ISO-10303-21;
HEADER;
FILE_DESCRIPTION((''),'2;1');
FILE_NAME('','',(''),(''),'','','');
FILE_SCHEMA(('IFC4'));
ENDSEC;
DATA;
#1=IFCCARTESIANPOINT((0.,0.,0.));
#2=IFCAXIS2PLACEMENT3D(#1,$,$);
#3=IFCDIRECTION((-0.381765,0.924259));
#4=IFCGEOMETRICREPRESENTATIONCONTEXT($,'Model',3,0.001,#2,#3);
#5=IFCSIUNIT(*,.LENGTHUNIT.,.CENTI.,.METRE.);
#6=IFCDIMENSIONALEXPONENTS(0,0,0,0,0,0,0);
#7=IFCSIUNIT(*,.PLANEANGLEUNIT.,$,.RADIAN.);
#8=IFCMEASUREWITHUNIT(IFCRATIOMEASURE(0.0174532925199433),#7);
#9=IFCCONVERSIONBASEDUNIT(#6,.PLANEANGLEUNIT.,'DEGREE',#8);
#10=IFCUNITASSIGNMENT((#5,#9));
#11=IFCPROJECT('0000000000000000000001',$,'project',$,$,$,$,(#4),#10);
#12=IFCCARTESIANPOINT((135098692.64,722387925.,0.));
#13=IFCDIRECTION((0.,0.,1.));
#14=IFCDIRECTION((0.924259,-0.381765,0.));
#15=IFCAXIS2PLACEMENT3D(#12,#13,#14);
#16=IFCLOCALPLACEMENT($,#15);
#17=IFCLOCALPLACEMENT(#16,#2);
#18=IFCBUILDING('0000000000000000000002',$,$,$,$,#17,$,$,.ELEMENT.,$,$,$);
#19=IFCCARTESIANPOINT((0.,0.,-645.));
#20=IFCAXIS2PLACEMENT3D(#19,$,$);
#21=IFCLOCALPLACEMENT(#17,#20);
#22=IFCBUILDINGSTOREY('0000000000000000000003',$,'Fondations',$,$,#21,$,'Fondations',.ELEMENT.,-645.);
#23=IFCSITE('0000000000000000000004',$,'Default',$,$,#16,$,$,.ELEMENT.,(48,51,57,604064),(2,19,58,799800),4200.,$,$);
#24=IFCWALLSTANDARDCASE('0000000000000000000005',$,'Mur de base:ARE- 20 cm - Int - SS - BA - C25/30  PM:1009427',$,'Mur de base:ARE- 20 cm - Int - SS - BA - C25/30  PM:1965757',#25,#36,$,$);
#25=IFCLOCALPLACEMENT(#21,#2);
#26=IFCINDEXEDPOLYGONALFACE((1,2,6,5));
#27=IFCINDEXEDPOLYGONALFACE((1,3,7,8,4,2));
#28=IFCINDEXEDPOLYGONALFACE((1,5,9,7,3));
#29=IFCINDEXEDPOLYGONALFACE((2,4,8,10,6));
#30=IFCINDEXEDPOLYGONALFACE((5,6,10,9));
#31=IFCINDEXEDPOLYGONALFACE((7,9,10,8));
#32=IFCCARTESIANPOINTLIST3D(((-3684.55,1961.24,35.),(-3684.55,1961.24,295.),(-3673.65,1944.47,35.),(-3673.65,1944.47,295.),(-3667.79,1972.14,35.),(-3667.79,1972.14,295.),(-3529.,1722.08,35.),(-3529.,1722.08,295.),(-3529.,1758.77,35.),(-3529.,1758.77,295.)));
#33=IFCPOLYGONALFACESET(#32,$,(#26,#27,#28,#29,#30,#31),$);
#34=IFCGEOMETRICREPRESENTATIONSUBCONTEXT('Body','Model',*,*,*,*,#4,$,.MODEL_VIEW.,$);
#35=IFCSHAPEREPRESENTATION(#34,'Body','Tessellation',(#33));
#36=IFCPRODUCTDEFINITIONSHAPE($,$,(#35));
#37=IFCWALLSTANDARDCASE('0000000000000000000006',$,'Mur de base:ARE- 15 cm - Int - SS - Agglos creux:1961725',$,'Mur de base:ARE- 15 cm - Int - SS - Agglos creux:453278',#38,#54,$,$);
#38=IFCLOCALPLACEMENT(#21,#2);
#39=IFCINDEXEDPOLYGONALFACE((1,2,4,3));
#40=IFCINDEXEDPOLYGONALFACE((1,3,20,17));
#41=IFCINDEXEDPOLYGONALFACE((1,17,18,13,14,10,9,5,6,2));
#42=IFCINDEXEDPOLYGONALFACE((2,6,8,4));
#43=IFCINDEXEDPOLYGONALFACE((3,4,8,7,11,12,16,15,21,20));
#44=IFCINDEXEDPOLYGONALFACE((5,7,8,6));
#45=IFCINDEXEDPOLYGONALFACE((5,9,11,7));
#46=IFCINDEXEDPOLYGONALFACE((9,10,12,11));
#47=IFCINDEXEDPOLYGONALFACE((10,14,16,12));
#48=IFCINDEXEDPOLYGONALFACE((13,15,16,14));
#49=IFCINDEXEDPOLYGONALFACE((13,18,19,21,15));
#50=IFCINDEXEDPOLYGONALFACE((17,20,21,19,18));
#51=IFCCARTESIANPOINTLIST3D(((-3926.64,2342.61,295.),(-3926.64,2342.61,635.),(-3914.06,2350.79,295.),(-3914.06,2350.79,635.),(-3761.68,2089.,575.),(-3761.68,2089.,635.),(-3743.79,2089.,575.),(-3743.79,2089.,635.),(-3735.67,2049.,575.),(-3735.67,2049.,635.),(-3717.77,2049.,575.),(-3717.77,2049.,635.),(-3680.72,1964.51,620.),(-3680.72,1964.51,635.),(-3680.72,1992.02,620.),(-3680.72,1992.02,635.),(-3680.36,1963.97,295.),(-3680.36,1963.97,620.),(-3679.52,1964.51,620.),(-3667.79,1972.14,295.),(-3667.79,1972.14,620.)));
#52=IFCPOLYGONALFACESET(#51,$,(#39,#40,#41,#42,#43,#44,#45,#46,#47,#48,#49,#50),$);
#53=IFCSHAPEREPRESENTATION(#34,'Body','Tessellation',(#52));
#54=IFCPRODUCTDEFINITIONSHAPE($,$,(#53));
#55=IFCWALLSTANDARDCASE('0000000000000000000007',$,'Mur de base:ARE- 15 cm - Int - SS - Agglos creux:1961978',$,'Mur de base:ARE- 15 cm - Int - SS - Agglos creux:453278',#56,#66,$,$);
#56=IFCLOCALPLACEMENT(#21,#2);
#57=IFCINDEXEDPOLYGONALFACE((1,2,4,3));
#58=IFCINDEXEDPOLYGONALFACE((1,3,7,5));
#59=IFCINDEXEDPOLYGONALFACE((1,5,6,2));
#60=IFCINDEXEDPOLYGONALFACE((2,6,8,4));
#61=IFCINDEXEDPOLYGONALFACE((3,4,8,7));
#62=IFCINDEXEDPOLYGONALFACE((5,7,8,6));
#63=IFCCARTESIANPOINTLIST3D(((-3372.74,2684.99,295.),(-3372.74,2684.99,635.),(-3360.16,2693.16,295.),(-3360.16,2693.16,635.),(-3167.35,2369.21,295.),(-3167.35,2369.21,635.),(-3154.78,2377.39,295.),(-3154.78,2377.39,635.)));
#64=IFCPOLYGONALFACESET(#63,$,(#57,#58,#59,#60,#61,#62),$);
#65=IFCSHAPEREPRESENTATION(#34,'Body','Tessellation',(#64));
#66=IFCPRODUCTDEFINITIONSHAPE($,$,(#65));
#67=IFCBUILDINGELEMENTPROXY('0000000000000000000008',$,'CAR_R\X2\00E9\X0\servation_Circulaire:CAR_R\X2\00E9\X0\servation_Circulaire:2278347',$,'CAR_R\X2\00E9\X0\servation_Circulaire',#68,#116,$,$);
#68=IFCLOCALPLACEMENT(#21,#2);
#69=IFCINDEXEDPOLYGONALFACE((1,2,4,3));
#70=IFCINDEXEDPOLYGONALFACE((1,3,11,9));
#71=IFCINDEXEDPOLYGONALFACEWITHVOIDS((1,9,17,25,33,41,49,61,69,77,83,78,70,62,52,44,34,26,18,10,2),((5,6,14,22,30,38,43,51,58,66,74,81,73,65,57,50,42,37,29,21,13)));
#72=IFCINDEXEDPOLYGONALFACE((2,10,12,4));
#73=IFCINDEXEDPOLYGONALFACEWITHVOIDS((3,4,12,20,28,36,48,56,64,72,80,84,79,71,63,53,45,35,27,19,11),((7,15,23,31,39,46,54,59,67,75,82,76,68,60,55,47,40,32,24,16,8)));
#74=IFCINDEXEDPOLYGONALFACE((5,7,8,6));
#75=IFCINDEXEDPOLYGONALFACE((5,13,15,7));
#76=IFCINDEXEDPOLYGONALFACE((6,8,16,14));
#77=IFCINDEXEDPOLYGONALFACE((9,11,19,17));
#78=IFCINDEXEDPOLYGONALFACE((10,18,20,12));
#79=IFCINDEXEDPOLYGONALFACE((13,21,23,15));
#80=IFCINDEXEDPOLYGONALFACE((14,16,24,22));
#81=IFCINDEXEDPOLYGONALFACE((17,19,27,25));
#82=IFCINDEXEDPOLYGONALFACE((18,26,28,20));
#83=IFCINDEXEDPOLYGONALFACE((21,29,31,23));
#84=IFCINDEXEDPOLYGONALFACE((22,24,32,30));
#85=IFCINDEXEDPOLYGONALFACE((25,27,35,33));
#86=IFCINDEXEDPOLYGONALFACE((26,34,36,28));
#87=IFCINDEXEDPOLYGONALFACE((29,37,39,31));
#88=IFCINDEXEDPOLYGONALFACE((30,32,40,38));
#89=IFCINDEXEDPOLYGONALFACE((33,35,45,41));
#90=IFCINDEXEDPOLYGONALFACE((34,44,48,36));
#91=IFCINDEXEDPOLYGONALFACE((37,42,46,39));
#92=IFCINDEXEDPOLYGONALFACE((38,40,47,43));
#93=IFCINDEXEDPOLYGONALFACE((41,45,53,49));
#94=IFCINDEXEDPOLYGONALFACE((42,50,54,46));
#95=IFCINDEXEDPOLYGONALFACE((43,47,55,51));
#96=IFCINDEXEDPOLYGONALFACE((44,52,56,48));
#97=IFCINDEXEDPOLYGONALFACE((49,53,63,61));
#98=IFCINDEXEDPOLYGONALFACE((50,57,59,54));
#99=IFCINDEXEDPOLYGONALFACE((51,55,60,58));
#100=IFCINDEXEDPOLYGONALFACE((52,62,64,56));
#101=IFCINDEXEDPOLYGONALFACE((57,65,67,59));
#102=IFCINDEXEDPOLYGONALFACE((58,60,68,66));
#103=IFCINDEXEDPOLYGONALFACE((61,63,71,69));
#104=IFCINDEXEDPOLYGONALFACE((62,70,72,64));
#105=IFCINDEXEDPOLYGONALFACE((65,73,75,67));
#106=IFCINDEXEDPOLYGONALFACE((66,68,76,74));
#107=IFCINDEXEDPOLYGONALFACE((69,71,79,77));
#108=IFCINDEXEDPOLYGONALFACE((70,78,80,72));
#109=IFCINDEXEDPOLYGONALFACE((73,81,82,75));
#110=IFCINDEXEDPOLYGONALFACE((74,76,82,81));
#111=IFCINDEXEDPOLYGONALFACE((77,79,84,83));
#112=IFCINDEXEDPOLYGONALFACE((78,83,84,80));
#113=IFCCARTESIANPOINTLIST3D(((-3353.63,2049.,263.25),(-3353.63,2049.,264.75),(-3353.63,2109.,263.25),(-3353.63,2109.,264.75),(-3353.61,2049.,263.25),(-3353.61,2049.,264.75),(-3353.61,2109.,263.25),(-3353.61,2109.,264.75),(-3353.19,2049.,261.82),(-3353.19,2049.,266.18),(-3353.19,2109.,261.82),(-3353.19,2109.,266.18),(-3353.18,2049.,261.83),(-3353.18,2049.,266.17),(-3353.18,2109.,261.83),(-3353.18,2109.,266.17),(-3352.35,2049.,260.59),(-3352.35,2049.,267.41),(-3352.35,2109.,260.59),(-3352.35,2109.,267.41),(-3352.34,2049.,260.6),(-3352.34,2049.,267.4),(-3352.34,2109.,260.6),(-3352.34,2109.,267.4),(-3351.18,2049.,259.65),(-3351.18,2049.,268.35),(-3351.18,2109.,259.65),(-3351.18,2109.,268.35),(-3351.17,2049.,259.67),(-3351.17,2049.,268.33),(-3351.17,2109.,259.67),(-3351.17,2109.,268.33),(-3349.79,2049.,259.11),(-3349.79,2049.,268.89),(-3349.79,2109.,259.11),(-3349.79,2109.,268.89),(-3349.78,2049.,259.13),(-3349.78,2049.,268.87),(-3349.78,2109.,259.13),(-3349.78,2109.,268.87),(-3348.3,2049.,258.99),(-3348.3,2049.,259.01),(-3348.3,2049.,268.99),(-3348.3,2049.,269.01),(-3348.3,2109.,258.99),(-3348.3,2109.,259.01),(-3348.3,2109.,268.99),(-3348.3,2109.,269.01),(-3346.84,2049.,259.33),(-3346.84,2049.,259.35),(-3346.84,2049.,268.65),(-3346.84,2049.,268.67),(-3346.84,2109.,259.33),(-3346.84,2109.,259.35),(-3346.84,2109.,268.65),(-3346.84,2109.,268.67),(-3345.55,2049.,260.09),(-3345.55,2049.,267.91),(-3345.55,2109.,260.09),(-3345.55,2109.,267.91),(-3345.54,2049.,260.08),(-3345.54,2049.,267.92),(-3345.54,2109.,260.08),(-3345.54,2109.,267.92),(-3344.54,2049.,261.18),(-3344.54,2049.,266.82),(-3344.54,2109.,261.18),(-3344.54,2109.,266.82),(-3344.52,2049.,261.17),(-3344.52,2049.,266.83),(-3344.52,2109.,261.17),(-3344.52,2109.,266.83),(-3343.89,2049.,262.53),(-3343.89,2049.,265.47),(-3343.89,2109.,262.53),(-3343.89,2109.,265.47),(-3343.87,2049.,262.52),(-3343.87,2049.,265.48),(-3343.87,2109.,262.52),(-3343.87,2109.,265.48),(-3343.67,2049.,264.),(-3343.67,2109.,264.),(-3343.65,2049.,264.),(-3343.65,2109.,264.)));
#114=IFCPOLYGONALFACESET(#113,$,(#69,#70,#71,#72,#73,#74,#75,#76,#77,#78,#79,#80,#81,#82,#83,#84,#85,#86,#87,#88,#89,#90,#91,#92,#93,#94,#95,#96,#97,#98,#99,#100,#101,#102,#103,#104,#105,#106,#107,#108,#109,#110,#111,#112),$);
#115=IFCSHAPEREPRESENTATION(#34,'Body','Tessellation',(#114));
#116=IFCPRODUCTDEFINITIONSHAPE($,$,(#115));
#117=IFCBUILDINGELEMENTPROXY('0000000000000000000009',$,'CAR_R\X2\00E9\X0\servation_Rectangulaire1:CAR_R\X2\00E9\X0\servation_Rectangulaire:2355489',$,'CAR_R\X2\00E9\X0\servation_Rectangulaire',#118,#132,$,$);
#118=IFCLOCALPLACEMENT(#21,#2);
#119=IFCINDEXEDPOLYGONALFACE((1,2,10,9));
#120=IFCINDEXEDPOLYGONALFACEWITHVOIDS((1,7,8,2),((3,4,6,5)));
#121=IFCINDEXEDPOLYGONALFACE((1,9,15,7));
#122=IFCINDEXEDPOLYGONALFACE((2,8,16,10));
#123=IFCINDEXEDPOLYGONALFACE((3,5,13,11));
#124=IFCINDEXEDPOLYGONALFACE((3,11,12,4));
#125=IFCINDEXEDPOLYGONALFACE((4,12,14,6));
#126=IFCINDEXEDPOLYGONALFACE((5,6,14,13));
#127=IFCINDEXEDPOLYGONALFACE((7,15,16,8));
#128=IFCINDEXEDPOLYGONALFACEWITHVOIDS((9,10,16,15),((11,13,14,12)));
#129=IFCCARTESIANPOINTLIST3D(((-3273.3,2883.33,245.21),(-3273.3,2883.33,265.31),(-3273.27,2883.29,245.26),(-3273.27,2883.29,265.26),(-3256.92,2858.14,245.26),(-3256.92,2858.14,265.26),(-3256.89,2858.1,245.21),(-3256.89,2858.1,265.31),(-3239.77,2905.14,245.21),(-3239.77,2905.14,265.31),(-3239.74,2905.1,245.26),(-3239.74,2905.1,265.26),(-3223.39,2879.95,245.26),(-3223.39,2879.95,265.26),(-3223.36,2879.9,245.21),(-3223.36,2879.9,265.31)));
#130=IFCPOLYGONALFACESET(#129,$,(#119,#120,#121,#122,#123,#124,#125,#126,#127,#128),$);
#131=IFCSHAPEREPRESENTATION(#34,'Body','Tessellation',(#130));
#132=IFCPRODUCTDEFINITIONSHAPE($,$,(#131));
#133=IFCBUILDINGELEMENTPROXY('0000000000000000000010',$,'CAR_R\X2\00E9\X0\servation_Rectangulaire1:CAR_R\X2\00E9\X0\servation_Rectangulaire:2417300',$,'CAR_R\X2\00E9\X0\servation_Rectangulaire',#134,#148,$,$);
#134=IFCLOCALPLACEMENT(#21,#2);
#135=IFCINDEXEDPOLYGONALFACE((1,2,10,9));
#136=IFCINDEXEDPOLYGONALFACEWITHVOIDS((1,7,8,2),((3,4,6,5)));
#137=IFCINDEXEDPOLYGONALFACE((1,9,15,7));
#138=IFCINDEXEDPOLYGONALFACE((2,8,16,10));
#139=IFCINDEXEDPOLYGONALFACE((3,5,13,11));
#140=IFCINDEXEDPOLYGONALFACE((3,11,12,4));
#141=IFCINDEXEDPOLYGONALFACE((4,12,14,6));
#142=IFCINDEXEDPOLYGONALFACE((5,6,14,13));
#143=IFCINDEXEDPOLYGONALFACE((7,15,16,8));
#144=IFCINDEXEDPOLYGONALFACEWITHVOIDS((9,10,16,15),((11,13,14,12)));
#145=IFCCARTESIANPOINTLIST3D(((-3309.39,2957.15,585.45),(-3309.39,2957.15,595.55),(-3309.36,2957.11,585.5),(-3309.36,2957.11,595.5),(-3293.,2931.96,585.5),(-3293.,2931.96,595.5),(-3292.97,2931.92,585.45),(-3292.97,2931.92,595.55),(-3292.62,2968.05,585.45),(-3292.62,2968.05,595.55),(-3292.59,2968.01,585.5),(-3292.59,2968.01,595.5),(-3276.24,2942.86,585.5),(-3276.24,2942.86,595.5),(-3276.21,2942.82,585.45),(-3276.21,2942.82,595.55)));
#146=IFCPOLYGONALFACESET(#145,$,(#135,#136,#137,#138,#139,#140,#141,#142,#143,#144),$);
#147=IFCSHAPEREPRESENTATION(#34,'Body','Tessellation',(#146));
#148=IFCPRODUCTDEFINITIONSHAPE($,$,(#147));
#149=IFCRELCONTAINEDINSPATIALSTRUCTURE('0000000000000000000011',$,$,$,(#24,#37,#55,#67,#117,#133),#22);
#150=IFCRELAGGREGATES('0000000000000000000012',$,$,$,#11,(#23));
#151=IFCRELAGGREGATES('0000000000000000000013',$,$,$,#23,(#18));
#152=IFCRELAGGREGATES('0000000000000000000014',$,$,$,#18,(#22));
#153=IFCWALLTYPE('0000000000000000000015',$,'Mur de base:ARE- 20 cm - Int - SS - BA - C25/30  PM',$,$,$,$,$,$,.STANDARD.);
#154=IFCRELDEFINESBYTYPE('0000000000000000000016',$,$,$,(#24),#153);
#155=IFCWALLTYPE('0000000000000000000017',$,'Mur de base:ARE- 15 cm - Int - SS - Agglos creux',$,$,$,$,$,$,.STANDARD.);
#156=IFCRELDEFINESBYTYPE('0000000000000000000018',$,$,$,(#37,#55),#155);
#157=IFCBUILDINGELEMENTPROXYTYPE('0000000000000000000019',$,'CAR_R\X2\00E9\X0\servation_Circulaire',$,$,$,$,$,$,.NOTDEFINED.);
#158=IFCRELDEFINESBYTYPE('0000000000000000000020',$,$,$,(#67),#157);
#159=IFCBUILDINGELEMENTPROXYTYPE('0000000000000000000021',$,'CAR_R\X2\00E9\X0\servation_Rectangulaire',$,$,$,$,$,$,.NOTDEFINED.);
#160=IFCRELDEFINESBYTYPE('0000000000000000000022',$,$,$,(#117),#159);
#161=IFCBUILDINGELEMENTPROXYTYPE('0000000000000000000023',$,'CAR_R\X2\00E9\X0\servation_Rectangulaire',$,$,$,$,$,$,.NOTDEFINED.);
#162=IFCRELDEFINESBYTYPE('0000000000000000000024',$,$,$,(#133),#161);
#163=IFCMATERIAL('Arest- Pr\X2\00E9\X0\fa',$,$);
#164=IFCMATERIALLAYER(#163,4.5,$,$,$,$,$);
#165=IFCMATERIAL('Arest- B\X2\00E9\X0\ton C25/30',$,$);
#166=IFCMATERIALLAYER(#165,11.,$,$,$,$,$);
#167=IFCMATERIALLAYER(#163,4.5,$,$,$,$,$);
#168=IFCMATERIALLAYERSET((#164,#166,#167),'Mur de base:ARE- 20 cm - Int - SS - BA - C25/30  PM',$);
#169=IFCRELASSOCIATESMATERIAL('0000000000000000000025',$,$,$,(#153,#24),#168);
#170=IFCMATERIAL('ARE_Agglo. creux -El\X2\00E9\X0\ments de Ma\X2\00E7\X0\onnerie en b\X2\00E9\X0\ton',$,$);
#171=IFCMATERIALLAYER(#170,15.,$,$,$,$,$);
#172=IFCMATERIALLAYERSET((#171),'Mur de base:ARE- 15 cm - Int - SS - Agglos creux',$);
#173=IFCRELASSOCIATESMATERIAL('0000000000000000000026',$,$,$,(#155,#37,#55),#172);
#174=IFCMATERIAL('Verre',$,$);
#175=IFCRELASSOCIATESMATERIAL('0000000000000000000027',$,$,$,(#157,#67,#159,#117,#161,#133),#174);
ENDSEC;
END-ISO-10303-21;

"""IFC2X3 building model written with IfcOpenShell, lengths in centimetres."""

from ifc_helpers import new_model, entity, si_unit, converted_unit, direction, frame, frame_2d, origin, place, context, subcontext, project, spatial, polyline, rectangle, hollow_circle, outline, extrude, clip, bounded_halfspace, source, transform, mapped, material, layer, layer_set, layer_usage, type_object, type_shapes, element, save


model = new_model("IFC2X3")

# Units and contexts
model_context = context("Model", 3, precision=0.001, world=origin(), true_north=direction((-0.381765, 0.924259)))
body_context = subcontext(model_context, "Body", "Model", "MODEL_VIEW")
ifc_project = project(units=[si_unit("LENGTHUNIT", "METRE", prefix="CENTI"), converted_unit("PLANEANGLEUNIT", "DEGREE", entity("IfcRatioMeasure", 0.0174532925199433), si_unit("PLANEANGLEUNIT", "RADIAN"), dimensions=[0, 0, 0, 0, 0, 0, 0])], contexts=[model_context])

# Site, building, storey
site_placement = place(None, frame((135098692.64, 722387925.0, 0.0), z_axis=(0.0, 0.0, 1.0), x_axis=(0.924259, -0.381765, 0.0)))
site = spatial("IfcSite", under=ifc_project, at=site_placement, Name="Default", CompositionType="ELEMENT", RefLatitude=(48, 51, 57, 604064), RefLongitude=(2, 19, 58, 799800), RefElevation=4200.0)
building_placement = place(site_placement, origin())
building = spatial("IfcBuilding", under=site, at=building_placement, CompositionType="ELEMENT")
storey_placement = place(building_placement, frame((0.0, 0.0, -645.0)))
storey = spatial("IfcBuildingStorey", under=building, at=storey_placement, Name="Fondations", LongName="Fondations", CompositionType="ELEMENT", Elevation=-645.0)

# Walls
ifc_material_1 = material(Name="Arest- Préfa")
ifc_layer_1 = layer(ifc_material_1, 4.5)
ifc_material_2 = material(Name="Arest- Béton C25/30")
ifc_layer_2 = layer(ifc_material_2, 11.0)
ifc_layer_3 = layer(ifc_material_1, 4.5)
ifc_layer_set_1 = layer_set([ifc_layer_1, ifc_layer_2, ifc_layer_3], Name="Mur de base:ARE- 20 cm - Int - SS - BA - C25/30  PM")
ifc_layer_usage_1 = layer_usage(ifc_layer_set_1, "AXIS2", "NEGATIVE", 10.0)
wall_type_1 = type_object("IfcWallType", Name="Mur de base:ARE- 20 cm - Int - SS - BA - C25/30  PM", PredefinedType="STANDARD", material=ifc_layer_set_1)
wall_1_placement = place(storey_placement, frame((-3676.17, 1966.69, 35.0), z_axis=(0.0, 0.0, 1.0), x_axis=(0.545236, -0.838282, 0.0)))
element("IfcWallStandardCase", 1, at=wall_1_placement, inside=storey, type_object=wall_type_1, material=ifc_layer_usage_1, Name="Mur de base:ARE- 20 cm - Int - SS - BA - C25/30  PM:1009427", ObjectType="Mur de base:ARE- 20 cm - Int - SS - BA - C25/30  PM:1965757", context=body_context, shape_type="SweptSolid", body=[
    extrude(outline(polyline([(285.29, -10.0), (254.54, 10.0), (0.0, 10.0), (0.0, -10.0), (20.0, -10.0), (285.29, -10.0)])), origin(), (0.0, 0.0, 1.0), 260.0),
])
ifc_material_3 = material(Name="ARE_Agglo. creux -Eléments de Maçonnerie en béton")
ifc_layer_4 = layer(ifc_material_3, 15.0)
ifc_layer_set_2 = layer_set([ifc_layer_4], Name="Mur de base:ARE- 15 cm - Int - SS - Agglos creux")
ifc_layer_usage_2 = layer_usage(ifc_layer_set_2, "AXIS2", "NEGATIVE", 7.5)
wall_type_2 = type_object("IfcWallType", Name="Mur de base:ARE- 15 cm - Int - SS - Agglos creux", PredefinedType="STANDARD", material=ifc_layer_set_2)
wall_2_placement = place(storey_placement, frame((-3674.07, 1968.06, 295.0), z_axis=(0.0, 0.0, 1.0), x_axis=(-0.545236, 0.838282, 0.0)))
element("IfcWallStandardCase", 2, at=wall_2_placement, inside=storey, type_object=wall_type_2, material=ifc_layer_usage_2, Name="Mur de base:ARE- 15 cm - Int - SS - Agglos creux:1961725", ObjectType="Mur de base:ARE- 15 cm - Int - SS - Agglos creux:453278", context=body_context, shape_type="Clipping", body=[
    clip(clip(clip(extrude(rectangle(XDim=451.69, YDim=15.0, at=frame_2d((225.85, 0.0), x_axis=(-1.0, 0.0))), origin(), (0.0, 0.0, 1.0), 340.0), bounded_halfspace(frame((101.44, 7.5, 280.0), z_axis=(0.0, 0.0, -1.0), x_axis=(0.545236, 0.838282, 0.0)), True, frame((101.44, 7.5, 280.0), z_axis=(0.0, 0.0, -1.0), x_axis=(0.545236, 0.838282, 0.0)), polyline([(0.0, 0.0), (26.02, 40.0), (8.12, 40.0), (-17.89, 0.0), (0.0, 0.0)]))), bounded_halfspace(frame((23.72, -7.5, 325.0), z_axis=(0.0, 0.0, -1.0), x_axis=(-0.838282, 0.545236, 0.0)), True, frame((23.72, -7.5, 325.0), z_axis=(0.0, 0.0, -1.0), x_axis=(-0.838282, 0.545236, 0.0)), polyline([(0.0, 0.0), (19.88, -12.93), (28.06, -0.36), (27.51, 0.0), (0.0, 0.0)]))), bounded_halfspace(frame((0.65, 7.5, 325.0), z_axis=(0.545236, 0.838282, 0.0), x_axis=(-0.838282, 0.545236, 0.0)), True, frame((0.65, 7.5, 325.0), z_axis=(0.545236, 0.838282, 0.0), x_axis=(-0.838282, 0.545236, 0.0)), polyline([(0.0, 0.0), (0.0, 15.0), (-27.51, 15.0), (-27.51, 0.0), (0.0, 0.0)]))),
])
ifc_layer_usage_3 = layer_usage(ifc_layer_set_2, "AXIS2", "NEGATIVE", 7.5)
wall_3_placement = place(storey_placement, frame((-3366.45, 2689.08, 295.0), z_axis=(0.0, 0.0, 1.0), x_axis=(0.545236, -0.838282, 0.0)))
element("IfcWallStandardCase", 3, at=wall_3_placement, inside=storey, type_object=wall_type_2, material=ifc_layer_usage_3, Name="Mur de base:ARE- 15 cm - Int - SS - Agglos creux:1961978", ObjectType="Mur de base:ARE- 15 cm - Int - SS - Agglos creux:453278", context=body_context, shape_type="SweptSolid", body=[
    extrude(rectangle(XDim=376.69, YDim=15.0, at=frame_2d((188.35, 0.0), x_axis=(-1.0, 0.0))), origin(), (0.0, 0.0, 1.0), 340.0),
])

# Building element proxies
ifc_material_4 = material(Name="Verre")
building_element_proxy_type_1 = type_object("IfcBuildingElementProxyType", Name="CAR_Réservation_Circulaire", PredefinedType="NOTDEFINED", material=ifc_material_4)
shared_shape_1 = source(origin(), body_context, "Body", "SweptSolid", [
    extrude(hollow_circle(Radius=5.02, WallThickness=0.02, at=frame_2d((0.0, 0.0), x_axis=(1.0, 0.0))), frame((0.0, 0.0, -60.0)), (0.0, 0.0, 1.0), 60.0),
])
type_shapes(building_element_proxy_type_1, [shared_shape_1])
proxy_1_placement = place(storey_placement, frame((-3348.67, 2109.0, 264.0), z_axis=(0.0, 1.0, 0.0), x_axis=(1.0, 0.0, 0.0)))
element("IfcBuildingElementProxy", 4, at=proxy_1_placement, inside=storey, type_object=building_element_proxy_type_1, material=ifc_material_4, Name="CAR_Réservation_Circulaire:CAR_Réservation_Circulaire:2278347", ObjectType="CAR_Réservation_Circulaire", context=body_context, shape_type="MappedRepresentation", body=[
    mapped(shared_shape_1, transform((0.0, 0.0, 0.0), scale=1.0)),
])
building_element_proxy_type_2 = type_object("IfcBuildingElementProxyType", Name="CAR_Réservation_Rectangulaire", PredefinedType="NOTDEFINED", material=ifc_material_4)
shared_shape_2 = source(origin(), body_context, "Body", "SweptSolid", [
    extrude(outline(polyline([(-15.05, -10.05), (15.05, -10.05), (15.05, 10.05), (-15.05, 10.05), (-15.05, -10.05)]), holes=[polyline([(15.0, -10.0), (-15.0, -10.0), (-15.0, 10.0), (15.0, 10.0), (15.0, -10.0)])]), frame((0.0, 0.0, -30.0), z_axis=(0.0, 0.0, 1.0), x_axis=(-1.0, 0.0, 0.0)), (0.0, 0.0, 1.0), 40.0),
])
type_shapes(building_element_proxy_type_2, [shared_shape_2])
proxy_2_placement = place(storey_placement, frame((-3239.95, 2887.07, 255.26), z_axis=(0.838282, 0.545236, 0.0), x_axis=(0.545236, -0.838282, 0.0)))
element("IfcBuildingElementProxy", 5, at=proxy_2_placement, inside=storey, type_object=building_element_proxy_type_2, material=ifc_material_4, Name="CAR_Réservation_Rectangulaire1:CAR_Réservation_Rectangulaire:2355489", ObjectType="CAR_Réservation_Rectangulaire", context=body_context, shape_type="MappedRepresentation", body=[
    mapped(shared_shape_2, transform((0.0, 0.0, 0.0), scale=1.0)),
])
building_element_proxy_type_3 = type_object("IfcBuildingElementProxyType", Name="CAR_Réservation_Rectangulaire", PredefinedType="NOTDEFINED", material=ifc_material_4)
shared_shape_3 = source(origin(), body_context, "Body", "SweptSolid", [
    extrude(outline(polyline([(-15.05, -5.05), (15.05, -5.05), (15.05, 5.05), (-15.05, 5.05), (-15.05, -5.05)]), holes=[polyline([(15.0, -5.0), (-15.0, -5.0), (-15.0, 5.0), (15.0, 5.0), (15.0, -5.0)])]), frame((0.0, 0.0, -20.0), z_axis=(0.0, 0.0, 1.0), x_axis=(-1.0, 0.0, 0.0)), (0.0, 0.0, 1.0), 20.0),
])
type_shapes(building_element_proxy_type_3, [shared_shape_3])
proxy_3_placement = place(storey_placement, frame((-3301.18, 2944.53, 590.5), z_axis=(-0.838282, -0.545236, 0.0), x_axis=(0.545236, -0.838282, 0.0)))
element("IfcBuildingElementProxy", 6, at=proxy_3_placement, inside=storey, type_object=building_element_proxy_type_3, material=ifc_material_4, Name="CAR_Réservation_Rectangulaire1:CAR_Réservation_Rectangulaire:2417300", ObjectType="CAR_Réservation_Rectangulaire", context=body_context, shape_type="MappedRepresentation", body=[
    mapped(shared_shape_3, transform((0.0, 0.0, 0.0), scale=1.0)),
])

save(model, "model.ifc")
